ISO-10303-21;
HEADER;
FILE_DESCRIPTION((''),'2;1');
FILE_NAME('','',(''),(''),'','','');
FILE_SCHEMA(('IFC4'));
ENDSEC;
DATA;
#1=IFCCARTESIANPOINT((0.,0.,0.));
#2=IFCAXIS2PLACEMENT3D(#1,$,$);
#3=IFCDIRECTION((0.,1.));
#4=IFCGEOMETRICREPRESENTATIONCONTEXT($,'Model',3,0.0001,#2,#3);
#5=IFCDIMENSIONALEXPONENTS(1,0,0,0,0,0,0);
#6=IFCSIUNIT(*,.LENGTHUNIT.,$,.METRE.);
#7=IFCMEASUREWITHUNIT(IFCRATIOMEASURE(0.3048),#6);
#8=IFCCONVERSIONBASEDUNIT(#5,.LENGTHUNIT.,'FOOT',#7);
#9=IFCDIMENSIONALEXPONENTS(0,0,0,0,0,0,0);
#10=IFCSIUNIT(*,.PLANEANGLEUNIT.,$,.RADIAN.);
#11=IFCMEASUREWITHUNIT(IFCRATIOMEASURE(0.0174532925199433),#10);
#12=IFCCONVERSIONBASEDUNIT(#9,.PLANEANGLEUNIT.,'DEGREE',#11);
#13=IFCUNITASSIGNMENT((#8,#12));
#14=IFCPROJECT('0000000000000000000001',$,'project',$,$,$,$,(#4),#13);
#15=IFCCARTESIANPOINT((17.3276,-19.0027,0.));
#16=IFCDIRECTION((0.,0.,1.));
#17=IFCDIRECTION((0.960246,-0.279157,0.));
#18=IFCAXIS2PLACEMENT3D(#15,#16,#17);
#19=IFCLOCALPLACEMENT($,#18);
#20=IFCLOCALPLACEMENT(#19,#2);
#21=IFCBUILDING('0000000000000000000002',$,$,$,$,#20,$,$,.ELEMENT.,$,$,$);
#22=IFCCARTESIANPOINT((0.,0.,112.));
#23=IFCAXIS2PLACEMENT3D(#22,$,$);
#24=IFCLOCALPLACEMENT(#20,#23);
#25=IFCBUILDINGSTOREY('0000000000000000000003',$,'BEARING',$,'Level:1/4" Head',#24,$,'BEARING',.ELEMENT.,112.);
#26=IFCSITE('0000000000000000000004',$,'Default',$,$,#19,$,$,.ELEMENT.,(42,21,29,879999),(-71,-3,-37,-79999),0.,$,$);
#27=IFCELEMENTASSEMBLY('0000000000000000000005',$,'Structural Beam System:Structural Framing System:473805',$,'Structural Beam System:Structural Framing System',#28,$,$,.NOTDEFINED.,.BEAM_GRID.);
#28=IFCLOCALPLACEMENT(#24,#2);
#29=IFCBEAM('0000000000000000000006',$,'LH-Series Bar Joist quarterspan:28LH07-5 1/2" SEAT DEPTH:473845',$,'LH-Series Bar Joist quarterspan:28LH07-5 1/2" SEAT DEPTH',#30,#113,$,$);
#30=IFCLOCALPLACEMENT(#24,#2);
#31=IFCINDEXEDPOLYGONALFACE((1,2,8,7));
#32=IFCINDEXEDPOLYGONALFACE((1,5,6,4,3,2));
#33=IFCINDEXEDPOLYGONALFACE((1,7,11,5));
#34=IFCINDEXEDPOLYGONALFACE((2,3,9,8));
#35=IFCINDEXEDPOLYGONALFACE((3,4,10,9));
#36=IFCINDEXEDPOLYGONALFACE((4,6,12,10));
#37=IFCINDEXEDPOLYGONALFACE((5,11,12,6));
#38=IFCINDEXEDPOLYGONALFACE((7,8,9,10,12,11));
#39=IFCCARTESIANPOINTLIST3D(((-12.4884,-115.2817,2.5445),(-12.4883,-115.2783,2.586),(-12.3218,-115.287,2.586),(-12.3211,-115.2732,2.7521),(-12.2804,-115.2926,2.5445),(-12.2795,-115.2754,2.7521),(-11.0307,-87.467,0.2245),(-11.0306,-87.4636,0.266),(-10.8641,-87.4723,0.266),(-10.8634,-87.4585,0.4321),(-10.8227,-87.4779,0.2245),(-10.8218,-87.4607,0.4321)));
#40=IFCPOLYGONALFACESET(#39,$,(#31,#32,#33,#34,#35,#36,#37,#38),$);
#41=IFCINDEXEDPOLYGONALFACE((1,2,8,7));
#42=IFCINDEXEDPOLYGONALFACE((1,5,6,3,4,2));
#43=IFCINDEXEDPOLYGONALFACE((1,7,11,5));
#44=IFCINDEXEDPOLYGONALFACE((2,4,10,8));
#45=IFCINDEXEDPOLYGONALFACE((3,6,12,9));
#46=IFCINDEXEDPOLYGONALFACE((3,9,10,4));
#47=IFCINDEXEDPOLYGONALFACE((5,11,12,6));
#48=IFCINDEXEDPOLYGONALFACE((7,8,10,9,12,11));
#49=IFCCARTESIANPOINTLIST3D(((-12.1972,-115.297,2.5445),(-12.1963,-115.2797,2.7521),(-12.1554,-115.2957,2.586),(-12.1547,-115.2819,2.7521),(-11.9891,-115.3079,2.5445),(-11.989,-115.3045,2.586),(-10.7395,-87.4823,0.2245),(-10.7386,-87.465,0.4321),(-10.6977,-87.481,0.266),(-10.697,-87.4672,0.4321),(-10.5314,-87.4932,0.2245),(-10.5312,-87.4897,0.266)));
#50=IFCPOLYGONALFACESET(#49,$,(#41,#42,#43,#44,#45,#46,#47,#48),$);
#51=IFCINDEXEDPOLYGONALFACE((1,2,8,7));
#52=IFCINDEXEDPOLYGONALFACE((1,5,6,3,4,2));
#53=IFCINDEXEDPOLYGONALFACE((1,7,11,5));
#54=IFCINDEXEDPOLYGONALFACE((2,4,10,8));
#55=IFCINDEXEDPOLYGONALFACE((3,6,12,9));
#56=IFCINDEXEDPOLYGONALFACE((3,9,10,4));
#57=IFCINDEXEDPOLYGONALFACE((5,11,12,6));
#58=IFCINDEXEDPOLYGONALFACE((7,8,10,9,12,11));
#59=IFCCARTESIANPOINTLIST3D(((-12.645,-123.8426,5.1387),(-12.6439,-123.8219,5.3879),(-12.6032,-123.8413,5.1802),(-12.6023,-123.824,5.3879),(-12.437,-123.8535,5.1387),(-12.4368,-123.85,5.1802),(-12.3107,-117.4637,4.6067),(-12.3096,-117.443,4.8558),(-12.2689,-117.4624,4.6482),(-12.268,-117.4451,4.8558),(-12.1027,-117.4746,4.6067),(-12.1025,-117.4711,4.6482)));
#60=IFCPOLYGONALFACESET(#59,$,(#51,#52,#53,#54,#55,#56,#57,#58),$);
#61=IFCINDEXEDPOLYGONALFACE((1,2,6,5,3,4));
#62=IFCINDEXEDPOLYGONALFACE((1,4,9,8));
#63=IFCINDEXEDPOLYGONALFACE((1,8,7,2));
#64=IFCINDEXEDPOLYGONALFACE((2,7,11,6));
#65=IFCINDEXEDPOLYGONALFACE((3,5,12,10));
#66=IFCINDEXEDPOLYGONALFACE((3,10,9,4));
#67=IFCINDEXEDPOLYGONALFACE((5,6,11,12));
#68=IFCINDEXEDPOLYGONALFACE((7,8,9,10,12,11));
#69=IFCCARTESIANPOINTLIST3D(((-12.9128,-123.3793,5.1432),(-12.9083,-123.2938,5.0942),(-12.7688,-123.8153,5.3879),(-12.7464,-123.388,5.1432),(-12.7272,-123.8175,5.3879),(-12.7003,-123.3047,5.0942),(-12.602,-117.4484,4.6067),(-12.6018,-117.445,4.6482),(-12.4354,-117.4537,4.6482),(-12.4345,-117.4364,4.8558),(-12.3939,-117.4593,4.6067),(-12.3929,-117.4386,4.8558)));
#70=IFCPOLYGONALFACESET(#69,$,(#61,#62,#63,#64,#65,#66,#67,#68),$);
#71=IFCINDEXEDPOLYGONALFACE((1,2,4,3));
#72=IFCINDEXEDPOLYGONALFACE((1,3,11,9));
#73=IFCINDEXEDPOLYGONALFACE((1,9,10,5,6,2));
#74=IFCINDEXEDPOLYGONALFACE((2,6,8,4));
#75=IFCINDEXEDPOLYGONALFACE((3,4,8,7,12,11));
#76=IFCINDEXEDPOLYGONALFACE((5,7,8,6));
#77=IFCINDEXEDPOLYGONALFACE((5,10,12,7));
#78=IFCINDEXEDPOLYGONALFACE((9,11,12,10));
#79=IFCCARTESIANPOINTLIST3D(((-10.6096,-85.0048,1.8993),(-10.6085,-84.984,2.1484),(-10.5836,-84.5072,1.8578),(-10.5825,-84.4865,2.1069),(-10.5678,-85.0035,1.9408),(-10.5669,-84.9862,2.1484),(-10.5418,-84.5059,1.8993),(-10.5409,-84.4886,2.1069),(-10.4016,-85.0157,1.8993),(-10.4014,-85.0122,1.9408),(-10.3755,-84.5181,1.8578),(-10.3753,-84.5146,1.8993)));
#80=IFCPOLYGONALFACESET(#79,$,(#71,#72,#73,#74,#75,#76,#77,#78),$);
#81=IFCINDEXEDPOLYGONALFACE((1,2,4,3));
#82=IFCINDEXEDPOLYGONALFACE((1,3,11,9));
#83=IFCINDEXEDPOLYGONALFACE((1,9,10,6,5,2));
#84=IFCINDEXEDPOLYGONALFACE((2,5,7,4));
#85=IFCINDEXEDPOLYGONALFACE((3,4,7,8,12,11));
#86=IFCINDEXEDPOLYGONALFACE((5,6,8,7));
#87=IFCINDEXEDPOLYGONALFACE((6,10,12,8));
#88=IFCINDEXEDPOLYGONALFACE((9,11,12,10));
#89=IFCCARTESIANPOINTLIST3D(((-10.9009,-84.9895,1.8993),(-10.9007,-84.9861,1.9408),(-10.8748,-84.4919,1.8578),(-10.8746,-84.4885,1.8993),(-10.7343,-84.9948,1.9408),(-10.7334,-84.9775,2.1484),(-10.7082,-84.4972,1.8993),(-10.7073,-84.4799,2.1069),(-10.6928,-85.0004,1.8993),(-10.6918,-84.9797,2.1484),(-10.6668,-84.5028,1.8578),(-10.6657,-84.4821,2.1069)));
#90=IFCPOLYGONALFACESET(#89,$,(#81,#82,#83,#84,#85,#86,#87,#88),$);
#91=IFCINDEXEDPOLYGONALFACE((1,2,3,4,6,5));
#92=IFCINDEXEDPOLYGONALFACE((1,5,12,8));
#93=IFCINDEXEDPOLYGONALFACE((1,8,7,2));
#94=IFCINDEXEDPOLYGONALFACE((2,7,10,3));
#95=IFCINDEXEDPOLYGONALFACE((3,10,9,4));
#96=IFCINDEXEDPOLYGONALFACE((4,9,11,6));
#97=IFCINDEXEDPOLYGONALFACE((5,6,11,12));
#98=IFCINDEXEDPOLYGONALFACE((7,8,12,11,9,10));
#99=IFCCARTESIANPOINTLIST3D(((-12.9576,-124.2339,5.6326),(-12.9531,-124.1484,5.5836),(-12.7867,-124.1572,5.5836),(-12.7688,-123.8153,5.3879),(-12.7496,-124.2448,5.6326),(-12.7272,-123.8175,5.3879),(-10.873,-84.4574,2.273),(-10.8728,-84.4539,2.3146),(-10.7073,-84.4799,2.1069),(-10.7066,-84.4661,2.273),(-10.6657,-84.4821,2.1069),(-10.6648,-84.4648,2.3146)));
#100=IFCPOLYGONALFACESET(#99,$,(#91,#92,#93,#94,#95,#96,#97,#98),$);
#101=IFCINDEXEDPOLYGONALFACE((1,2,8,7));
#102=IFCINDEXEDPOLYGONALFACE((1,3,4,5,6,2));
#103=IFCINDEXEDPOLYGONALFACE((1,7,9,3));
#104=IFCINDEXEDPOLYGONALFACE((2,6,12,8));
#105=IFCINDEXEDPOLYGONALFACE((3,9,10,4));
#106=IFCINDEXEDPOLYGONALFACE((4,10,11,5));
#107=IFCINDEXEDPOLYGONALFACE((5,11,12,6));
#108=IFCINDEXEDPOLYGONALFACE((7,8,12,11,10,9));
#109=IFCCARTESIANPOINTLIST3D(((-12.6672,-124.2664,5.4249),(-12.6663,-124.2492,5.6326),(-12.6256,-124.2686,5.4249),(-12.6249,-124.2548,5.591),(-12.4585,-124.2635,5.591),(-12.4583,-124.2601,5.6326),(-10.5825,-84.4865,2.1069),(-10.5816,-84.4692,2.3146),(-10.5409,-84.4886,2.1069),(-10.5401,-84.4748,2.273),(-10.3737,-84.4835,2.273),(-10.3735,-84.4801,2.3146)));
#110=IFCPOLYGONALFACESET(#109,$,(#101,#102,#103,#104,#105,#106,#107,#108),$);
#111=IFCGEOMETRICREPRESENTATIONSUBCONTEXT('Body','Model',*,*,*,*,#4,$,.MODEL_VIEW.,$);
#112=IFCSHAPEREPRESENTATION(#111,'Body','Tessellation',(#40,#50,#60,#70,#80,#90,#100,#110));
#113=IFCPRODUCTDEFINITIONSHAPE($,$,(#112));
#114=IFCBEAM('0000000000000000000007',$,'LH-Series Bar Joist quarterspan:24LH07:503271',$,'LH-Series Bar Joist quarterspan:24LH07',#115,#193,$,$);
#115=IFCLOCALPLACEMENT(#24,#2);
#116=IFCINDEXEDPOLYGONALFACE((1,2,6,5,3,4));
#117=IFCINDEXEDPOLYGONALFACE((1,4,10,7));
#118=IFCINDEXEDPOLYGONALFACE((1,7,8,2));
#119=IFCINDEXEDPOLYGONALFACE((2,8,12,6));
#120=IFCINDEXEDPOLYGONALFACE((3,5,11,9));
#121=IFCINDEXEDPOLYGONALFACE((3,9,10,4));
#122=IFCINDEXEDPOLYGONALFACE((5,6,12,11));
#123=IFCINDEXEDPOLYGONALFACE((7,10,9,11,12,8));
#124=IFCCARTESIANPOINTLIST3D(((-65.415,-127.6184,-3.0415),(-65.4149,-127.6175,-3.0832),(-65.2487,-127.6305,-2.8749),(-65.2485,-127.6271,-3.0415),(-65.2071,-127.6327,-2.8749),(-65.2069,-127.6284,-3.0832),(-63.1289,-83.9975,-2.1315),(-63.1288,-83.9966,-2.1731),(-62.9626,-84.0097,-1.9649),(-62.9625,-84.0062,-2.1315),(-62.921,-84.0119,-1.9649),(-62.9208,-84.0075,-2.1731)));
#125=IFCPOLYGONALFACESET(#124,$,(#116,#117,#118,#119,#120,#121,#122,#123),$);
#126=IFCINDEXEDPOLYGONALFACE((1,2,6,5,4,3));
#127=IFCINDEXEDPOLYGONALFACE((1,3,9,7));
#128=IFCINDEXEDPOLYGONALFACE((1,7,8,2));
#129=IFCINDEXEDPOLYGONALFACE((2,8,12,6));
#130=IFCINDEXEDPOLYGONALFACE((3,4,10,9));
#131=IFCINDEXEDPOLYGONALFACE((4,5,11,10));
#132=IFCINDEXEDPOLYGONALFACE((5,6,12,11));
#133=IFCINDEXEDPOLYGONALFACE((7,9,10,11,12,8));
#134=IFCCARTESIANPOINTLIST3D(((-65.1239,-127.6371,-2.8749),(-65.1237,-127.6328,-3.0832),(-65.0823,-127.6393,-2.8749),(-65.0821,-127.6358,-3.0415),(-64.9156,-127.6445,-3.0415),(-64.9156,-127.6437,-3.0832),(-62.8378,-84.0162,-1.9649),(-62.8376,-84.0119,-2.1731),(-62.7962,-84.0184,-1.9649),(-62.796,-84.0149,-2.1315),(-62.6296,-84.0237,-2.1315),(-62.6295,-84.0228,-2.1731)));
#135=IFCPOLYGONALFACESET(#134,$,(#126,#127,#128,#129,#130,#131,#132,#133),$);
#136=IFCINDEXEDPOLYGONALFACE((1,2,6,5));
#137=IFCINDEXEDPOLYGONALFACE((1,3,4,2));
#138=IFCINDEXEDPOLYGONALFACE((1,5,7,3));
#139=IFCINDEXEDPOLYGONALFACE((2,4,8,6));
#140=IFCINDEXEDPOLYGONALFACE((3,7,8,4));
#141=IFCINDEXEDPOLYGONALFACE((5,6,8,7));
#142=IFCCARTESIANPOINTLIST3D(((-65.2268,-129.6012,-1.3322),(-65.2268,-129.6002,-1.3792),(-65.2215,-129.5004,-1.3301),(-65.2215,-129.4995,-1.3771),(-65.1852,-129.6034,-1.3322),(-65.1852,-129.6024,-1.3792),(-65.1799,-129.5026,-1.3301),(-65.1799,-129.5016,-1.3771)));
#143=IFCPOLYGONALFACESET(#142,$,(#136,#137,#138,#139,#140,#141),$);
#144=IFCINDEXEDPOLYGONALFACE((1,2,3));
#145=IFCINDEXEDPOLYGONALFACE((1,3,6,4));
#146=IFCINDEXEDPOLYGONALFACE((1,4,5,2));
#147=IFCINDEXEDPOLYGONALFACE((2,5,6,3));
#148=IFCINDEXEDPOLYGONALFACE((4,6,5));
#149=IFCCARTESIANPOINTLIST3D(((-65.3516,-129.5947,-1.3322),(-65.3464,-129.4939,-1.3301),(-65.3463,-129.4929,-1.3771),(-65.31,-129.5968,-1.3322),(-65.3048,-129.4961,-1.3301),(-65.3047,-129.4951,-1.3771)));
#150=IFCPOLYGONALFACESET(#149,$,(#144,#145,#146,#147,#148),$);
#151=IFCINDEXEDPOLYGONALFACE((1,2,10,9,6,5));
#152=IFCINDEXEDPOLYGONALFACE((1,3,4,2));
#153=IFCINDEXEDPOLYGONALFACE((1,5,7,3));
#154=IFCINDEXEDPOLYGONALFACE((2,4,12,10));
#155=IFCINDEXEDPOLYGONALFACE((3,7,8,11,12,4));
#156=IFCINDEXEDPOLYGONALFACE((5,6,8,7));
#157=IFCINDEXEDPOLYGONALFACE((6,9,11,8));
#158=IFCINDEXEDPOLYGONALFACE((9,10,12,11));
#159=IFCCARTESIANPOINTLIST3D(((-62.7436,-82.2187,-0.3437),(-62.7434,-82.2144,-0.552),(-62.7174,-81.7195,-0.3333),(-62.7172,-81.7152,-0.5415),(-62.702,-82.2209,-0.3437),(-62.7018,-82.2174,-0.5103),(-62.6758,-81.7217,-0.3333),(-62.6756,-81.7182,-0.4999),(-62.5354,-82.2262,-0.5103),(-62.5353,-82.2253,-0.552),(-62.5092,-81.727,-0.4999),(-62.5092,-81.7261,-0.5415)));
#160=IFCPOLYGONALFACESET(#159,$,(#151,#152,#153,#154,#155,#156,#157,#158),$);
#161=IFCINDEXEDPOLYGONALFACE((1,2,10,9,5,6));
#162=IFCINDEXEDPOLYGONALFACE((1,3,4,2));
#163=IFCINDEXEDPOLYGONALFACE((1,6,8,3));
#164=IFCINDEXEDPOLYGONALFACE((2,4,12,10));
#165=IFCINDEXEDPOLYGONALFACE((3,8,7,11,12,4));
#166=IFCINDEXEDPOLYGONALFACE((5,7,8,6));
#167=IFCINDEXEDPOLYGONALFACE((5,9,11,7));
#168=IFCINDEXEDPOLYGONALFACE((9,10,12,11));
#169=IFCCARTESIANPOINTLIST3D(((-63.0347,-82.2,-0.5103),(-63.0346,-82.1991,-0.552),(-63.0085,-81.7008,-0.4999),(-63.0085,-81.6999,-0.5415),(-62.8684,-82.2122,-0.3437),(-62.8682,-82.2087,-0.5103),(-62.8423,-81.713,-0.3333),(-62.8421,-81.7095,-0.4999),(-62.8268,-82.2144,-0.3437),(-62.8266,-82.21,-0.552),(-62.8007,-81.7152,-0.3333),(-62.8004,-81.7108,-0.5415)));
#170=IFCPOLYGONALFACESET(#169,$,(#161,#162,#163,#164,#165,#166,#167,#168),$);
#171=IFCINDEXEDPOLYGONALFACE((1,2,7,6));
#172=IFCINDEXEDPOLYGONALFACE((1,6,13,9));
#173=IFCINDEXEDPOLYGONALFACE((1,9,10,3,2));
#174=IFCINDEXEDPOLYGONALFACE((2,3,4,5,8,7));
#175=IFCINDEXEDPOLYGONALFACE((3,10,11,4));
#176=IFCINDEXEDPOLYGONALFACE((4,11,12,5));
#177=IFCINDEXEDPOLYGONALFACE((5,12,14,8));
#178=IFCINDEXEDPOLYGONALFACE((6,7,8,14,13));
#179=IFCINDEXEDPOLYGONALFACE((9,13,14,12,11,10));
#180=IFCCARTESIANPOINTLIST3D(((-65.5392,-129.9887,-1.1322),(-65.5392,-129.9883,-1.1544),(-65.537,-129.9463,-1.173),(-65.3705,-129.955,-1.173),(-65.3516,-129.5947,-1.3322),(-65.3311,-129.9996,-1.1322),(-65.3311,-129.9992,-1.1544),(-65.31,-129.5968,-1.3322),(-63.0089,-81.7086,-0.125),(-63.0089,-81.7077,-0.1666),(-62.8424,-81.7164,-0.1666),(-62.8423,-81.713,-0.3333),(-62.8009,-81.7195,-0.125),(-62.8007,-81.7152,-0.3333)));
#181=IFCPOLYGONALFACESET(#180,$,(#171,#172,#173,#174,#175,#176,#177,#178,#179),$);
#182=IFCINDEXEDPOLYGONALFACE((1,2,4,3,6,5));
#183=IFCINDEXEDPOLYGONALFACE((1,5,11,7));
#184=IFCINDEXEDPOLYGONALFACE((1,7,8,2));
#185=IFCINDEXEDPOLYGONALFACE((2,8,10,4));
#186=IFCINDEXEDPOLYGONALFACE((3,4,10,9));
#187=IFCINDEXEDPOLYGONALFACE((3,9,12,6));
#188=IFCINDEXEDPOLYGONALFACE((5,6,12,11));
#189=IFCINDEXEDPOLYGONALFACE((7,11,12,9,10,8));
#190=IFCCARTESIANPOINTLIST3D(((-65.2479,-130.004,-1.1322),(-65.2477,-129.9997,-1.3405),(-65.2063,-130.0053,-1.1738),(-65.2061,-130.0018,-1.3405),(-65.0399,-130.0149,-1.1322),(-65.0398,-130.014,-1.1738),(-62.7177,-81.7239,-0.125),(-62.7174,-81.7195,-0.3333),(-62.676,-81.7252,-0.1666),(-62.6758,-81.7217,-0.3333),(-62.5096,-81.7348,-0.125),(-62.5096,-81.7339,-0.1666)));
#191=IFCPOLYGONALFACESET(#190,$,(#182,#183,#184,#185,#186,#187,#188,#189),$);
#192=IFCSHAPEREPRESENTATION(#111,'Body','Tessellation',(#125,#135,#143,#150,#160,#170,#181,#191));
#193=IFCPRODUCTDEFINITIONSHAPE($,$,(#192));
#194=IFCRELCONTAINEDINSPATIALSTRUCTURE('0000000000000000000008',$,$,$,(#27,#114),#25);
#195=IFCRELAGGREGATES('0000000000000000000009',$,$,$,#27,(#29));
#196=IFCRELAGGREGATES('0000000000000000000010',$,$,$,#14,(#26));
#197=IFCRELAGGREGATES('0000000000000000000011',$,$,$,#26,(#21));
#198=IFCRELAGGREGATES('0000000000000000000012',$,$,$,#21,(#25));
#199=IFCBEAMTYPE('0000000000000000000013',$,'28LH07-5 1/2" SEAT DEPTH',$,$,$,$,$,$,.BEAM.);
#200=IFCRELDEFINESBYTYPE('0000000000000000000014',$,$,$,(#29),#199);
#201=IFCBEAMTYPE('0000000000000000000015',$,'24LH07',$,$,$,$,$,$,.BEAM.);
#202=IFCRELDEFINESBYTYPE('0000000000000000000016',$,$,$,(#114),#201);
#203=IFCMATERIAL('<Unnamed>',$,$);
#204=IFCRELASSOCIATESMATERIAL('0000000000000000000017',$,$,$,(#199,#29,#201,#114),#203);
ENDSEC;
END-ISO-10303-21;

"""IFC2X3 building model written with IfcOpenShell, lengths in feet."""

from ifc_helpers import new_model, entity, si_unit, converted_unit, direction, frame, frame_2d, origin, origin_2d_with_axis, place, context, subcontext, project, spatial, polyline, rectangle, outline, extrude, clip, halfspace, source, transform, mapped, material, type_object, type_shapes, element, aggregate, save


model = new_model("IFC2X3")

# Units and contexts
model_context = context("Model", 3, precision=0.0001, world=origin(), true_north=direction((0.0, 1.0)))
body_context = subcontext(model_context, "Body", "Model", "MODEL_VIEW")
ifc_project = project(units=[converted_unit("LENGTHUNIT", "FOOT", entity("IfcRatioMeasure", 0.3048), si_unit("LENGTHUNIT", "METRE"), dimensions=[1, 0, 0, 0, 0, 0, 0]), converted_unit("PLANEANGLEUNIT", "DEGREE", entity("IfcRatioMeasure", 0.0174532925199433), si_unit("PLANEANGLEUNIT", "RADIAN"), dimensions=[0, 0, 0, 0, 0, 0, 0])], contexts=[model_context])

# Site, building, storey
site_placement = place(None, frame((17.3276, -19.0027, 0.0), z_axis=(0.0, 0.0, 1.0), x_axis=(0.960246, -0.279157, 0.0)))
site = spatial("IfcSite", under=ifc_project, at=site_placement, Name="Default", CompositionType="ELEMENT", RefLatitude=(42, 21, 29, 879999), RefLongitude=(-71, -3, -37, -79999), RefElevation=0.0)
building_placement = place(site_placement, origin())
building = spatial("IfcBuilding", under=site, at=building_placement, CompositionType="ELEMENT")
storey_placement = place(building_placement, frame((0.0, 0.0, 112.0)))
storey = spatial("IfcBuildingStorey", under=building, at=storey_placement, Name="BEARING", ObjectType="Level:1/4\" Head", LongName="BEARING", CompositionType="ELEMENT", Elevation=112.0)

# Shared definitions
ifc_material_1 = material(Name="<Unnamed>")

# Element assembly, beam
assembly_placement = place(storey_placement, origin())
assembly = element("IfcElementAssembly", 1, at=assembly_placement, inside=storey, Name="Structural Beam System:Structural Framing System:473805", ObjectType="Structural Beam System:Structural Framing System", AssemblyPlace="NOTDEFINED", PredefinedType="BEAM_GRID")
beam_type_1 = type_object("IfcBeamType", Name="28LH07-5 1/2\" SEAT DEPTH", PredefinedType="BEAM", material=ifc_material_1)
shared_shape_1 = source(origin(), body_context, "Body", "SweptSolid", [
    extrude(outline(polyline([(-0.0833, -0.0833), (0.125, -0.0833), (0.125, -0.0417), (-0.0417, -0.0417), (-0.0417, 0.125), (-0.0833, 0.125), (-0.0833, -0.0833)])), frame((-10.9055, -87.4667, 112.3075), z_axis=(-0.052155, -0.995183, 0.083007), x_axis=(0.004344, 0.082893, 0.996549)), (0.0, 0.0, 1.0), 27.9493),
    extrude(outline(polyline([(-0.125, -0.0417), (-0.125, -0.0833), (0.0833, -0.0833), (0.0833, 0.125), (0.0417, 0.125), (0.0417, -0.0417), (-0.125, -0.0417)])), frame((-10.6559, -87.4797, 112.3075), z_axis=(0.052155, 0.995183, -0.083007), x_axis=(-0.99863, 0.052336, 0.0)), (0.0, 0.0, -1.0), 27.9493),
    extrude(outline(polyline([(-0.125, -0.0556), (-0.125, -0.0972), (0.0833, -0.0972), (0.0833, 0.1528), (0.0417, 0.1528), (0.0417, -0.0556), (-0.125, -0.0556)])), frame((-12.2271, -117.46, 116.7036), z_axis=(0.052155, 0.995183, -0.083007), x_axis=(-0.99863, 0.052336, 0.0)), (0.0, 0.0, -1.0), 6.4098),
    clip(extrude(outline(polyline([(-0.0972, -0.0833), (0.1528, -0.0833), (0.1528, -0.0417), (-0.0556, -0.0417), (-0.0556, 0.125), (-0.0972, 0.125), (-0.0972, -0.0833)])), frame((-12.4767, -117.4469, 116.7036), z_axis=(-0.052155, -0.995183, 0.083007), x_axis=(0.004344, 0.082893, 0.996549)), (0.0, 0.0, 1.0), 6.4098), halfspace(frame((-52.6301, -122.1585, 117.6347), z_axis=(-0.025981, -0.495743, -0.868081), x_axis=(0.99863, -0.052336, 0.0)), False)),
    extrude(outline(polyline([(-0.0972, -0.125), (-0.0556, -0.125), (-0.0556, 0.0417), (0.1528, 0.0417), (0.1528, 0.0833), (-0.0972, 0.0833), (-0.0972, -0.125)])), frame((-10.4999, -84.5035, 113.9547), z_axis=(-0.052155, -0.995183, 0.083007), x_axis=(0.004344, 0.082893, 0.996549)), (0.0, 0.0, 1.0), 0.5),
    extrude(outline(polyline([(-0.0972, -0.0833), (0.1528, -0.0833), (0.1528, -0.0417), (-0.0556, -0.0417), (-0.0556, 0.125), (-0.0972, 0.125), (-0.0972, -0.0833)])), frame((-10.7496, -84.4904, 113.9547), z_axis=(-0.052155, -0.995183, 0.083007), x_axis=(0.004344, 0.082893, 0.996549)), (0.0, 0.0, 1.0), 0.5),
    clip(extrude(outline(polyline([(-0.0833, -0.0833), (0.125, -0.0833), (0.125, -0.0417), (-0.0417, -0.0417), (-0.0417, 0.125), (-0.0833, 0.125), (-0.0833, -0.0833)])), frame((-10.7484, -84.4674, 114.2315), z_axis=(-0.052155, -0.995183, 0.083007), x_axis=(-0.99863, 0.052336, 0.0)), (0.0, 0.0, 1.0), 39.9725), halfspace(frame((-52.6301, -122.1585, 117.6347), z_axis=(-0.025981, -0.495743, -0.868081), x_axis=(0.99863, -0.052336, 0.0)), False)),
    extrude(outline(polyline([(-0.125, -0.0833), (0.0833, -0.0833), (0.0833, 0.125), (0.0417, 0.125), (0.0417, -0.0417), (-0.125, -0.0417), (-0.125, -0.0833)])), frame((-10.4987, -84.4805, 114.2315), z_axis=(-0.052155, -0.995183, 0.083007), x_axis=(-0.99863, 0.052336, 0.0)), (0.0, 0.0, 1.0), 39.9725),
])
type_shapes(beam_type_1, [shared_shape_1])
beam_1_placement = place(assembly_placement, frame((0.0, 0.0, -112.0)))
beam_1 = element("IfcBeam", 2, at=beam_1_placement, type_object=beam_type_1, material=ifc_material_1, Name="LH-Series Bar Joist quarterspan:28LH07-5 1/2\" SEAT DEPTH:473845", ObjectType="LH-Series Bar Joist quarterspan:28LH07-5 1/2\" SEAT DEPTH", context=body_context, shape_type="MappedRepresentation", body=[
    mapped(shared_shape_1, transform((0.0, 0.0, 0.0), scale=1.0)),
])
aggregate(assembly, [beam_1])

# Beam
beam_type_2 = type_object("IfcBeamType", Name="24LH07", PredefinedType="BEAM", material=ifc_material_1)
shared_shape_2 = source(origin(), body_context, "Body", "SweptSolid", [
    extrude(outline(polyline([(-0.0833, -0.0833), (0.125, -0.0833), (0.125, -0.0417), (-0.0417, -0.0417), (-0.0417, 0.125), (-0.0833, 0.125), (-0.0833, -0.0833)])), frame((-63.0041, -84.0049, 109.9102), z_axis=(-0.052325, -0.998413, -0.020829), x_axis=(-0.00109, -0.0208, 0.999783)), (0.0, 0.0, 1.0), 43.6902),
    extrude(outline(polyline([(-0.125, -0.0417), (-0.125, -0.0833), (0.0833, -0.0833), (0.0833, 0.125), (0.0417, 0.125), (0.0417, -0.0417), (-0.125, -0.0417)])), frame((-62.7544, -84.018, 109.9102), z_axis=(0.052325, 0.998413, 0.020829), x_axis=(-0.99863, 0.052336, 0.0)), (0.0, 0.0, -1.0), 43.6902),
    extrude(rectangle(XDim=0.0471, YDim=0.0417, at=origin_2d_with_axis()), frame((-65.2007, -129.501, 110.6464), z_axis=(-0.052325, -0.998413, -0.020829), x_axis=(-0.00109, -0.0208, 0.999783)), (0.0, 0.0, 1.0), 0.1009),
    clip(extrude(rectangle(XDim=0.0471, YDim=0.0417, at=frame_2d((0.0, 0.0), x_axis=(1.0, 0.0))), frame((-65.3255, -129.4945, 110.6464), z_axis=(-0.052325, -0.998413, -0.020829), x_axis=(-0.00109, -0.0208, 0.999783)), (0.0, 0.0, 1.0), 0.1009), halfspace(frame((-113.5801, -127.4705, 110.8456), z_axis=(-0.021125, -0.403096, -0.914914), x_axis=(0.99863, -0.052336, 0.0)), False)),
    extrude(outline(polyline([(-0.0833, -0.125), (-0.0417, -0.125), (-0.0417, 0.0417), (0.125, 0.0417), (0.125, 0.0833), (-0.0833, 0.0833), (-0.0833, -0.125)])), frame((-62.6341, -81.7213, 111.5418), z_axis=(-0.052325, -0.998413, -0.020829), x_axis=(-0.00109, -0.0208, 0.999783)), (0.0, 0.0, 1.0), 0.5),
    extrude(outline(polyline([(-0.0833, -0.0833), (0.125, -0.0833), (0.125, -0.0417), (-0.0417, -0.0417), (-0.0417, 0.125), (-0.0833, 0.125), (-0.0833, -0.0833)])), frame((-62.8837, -81.7082, 111.5418), z_axis=(-0.052325, -0.998413, -0.020829), x_axis=(-0.00109, -0.0208, 0.999783)), (0.0, 0.0, 1.0), 0.5),
    clip(extrude(outline(polyline([(-0.0833, -0.0833), (0.125, -0.0833), (0.125, -0.0417), (-0.0417, -0.0417), (-0.0417, 0.125), (-0.0833, 0.125), (-0.0833, -0.0833)])), frame((-62.884, -81.7134, 111.7917), z_axis=(-0.052325, -0.998413, -0.020829), x_axis=(-0.99863, 0.052336, 0.0)), (0.0, 0.0, 1.0), 48.3569), halfspace(frame((-113.5801, -127.4705, 110.8456), z_axis=(-0.021125, -0.403096, -0.914914), x_axis=(0.99863, -0.052336, 0.0)), False)),
    extrude(outline(polyline([(-0.125, -0.0833), (0.0833, -0.0833), (0.0833, 0.125), (0.0417, 0.125), (0.0417, -0.0417), (-0.125, -0.0417), (-0.125, -0.0833)])), frame((-62.6344, -81.7265, 111.7917), z_axis=(-0.052325, -0.998413, -0.020829), x_axis=(-0.99863, 0.052336, 0.0)), (0.0, 0.0, 1.0), 48.3569),
])
type_shapes(beam_type_2, [shared_shape_2])
beam_2_placement = place(storey_placement, frame((0.0, 0.0, -112.0)))
element("IfcBeam", 3, at=beam_2_placement, inside=storey, type_object=beam_type_2, material=ifc_material_1, Name="LH-Series Bar Joist quarterspan:24LH07:503271", ObjectType="LH-Series Bar Joist quarterspan:24LH07", context=body_context, shape_type="MappedRepresentation", body=[
    mapped(shared_shape_2, transform((0.0, 0.0, 0.0), scale=1.0)),
])

save(model, "model.ifc")
